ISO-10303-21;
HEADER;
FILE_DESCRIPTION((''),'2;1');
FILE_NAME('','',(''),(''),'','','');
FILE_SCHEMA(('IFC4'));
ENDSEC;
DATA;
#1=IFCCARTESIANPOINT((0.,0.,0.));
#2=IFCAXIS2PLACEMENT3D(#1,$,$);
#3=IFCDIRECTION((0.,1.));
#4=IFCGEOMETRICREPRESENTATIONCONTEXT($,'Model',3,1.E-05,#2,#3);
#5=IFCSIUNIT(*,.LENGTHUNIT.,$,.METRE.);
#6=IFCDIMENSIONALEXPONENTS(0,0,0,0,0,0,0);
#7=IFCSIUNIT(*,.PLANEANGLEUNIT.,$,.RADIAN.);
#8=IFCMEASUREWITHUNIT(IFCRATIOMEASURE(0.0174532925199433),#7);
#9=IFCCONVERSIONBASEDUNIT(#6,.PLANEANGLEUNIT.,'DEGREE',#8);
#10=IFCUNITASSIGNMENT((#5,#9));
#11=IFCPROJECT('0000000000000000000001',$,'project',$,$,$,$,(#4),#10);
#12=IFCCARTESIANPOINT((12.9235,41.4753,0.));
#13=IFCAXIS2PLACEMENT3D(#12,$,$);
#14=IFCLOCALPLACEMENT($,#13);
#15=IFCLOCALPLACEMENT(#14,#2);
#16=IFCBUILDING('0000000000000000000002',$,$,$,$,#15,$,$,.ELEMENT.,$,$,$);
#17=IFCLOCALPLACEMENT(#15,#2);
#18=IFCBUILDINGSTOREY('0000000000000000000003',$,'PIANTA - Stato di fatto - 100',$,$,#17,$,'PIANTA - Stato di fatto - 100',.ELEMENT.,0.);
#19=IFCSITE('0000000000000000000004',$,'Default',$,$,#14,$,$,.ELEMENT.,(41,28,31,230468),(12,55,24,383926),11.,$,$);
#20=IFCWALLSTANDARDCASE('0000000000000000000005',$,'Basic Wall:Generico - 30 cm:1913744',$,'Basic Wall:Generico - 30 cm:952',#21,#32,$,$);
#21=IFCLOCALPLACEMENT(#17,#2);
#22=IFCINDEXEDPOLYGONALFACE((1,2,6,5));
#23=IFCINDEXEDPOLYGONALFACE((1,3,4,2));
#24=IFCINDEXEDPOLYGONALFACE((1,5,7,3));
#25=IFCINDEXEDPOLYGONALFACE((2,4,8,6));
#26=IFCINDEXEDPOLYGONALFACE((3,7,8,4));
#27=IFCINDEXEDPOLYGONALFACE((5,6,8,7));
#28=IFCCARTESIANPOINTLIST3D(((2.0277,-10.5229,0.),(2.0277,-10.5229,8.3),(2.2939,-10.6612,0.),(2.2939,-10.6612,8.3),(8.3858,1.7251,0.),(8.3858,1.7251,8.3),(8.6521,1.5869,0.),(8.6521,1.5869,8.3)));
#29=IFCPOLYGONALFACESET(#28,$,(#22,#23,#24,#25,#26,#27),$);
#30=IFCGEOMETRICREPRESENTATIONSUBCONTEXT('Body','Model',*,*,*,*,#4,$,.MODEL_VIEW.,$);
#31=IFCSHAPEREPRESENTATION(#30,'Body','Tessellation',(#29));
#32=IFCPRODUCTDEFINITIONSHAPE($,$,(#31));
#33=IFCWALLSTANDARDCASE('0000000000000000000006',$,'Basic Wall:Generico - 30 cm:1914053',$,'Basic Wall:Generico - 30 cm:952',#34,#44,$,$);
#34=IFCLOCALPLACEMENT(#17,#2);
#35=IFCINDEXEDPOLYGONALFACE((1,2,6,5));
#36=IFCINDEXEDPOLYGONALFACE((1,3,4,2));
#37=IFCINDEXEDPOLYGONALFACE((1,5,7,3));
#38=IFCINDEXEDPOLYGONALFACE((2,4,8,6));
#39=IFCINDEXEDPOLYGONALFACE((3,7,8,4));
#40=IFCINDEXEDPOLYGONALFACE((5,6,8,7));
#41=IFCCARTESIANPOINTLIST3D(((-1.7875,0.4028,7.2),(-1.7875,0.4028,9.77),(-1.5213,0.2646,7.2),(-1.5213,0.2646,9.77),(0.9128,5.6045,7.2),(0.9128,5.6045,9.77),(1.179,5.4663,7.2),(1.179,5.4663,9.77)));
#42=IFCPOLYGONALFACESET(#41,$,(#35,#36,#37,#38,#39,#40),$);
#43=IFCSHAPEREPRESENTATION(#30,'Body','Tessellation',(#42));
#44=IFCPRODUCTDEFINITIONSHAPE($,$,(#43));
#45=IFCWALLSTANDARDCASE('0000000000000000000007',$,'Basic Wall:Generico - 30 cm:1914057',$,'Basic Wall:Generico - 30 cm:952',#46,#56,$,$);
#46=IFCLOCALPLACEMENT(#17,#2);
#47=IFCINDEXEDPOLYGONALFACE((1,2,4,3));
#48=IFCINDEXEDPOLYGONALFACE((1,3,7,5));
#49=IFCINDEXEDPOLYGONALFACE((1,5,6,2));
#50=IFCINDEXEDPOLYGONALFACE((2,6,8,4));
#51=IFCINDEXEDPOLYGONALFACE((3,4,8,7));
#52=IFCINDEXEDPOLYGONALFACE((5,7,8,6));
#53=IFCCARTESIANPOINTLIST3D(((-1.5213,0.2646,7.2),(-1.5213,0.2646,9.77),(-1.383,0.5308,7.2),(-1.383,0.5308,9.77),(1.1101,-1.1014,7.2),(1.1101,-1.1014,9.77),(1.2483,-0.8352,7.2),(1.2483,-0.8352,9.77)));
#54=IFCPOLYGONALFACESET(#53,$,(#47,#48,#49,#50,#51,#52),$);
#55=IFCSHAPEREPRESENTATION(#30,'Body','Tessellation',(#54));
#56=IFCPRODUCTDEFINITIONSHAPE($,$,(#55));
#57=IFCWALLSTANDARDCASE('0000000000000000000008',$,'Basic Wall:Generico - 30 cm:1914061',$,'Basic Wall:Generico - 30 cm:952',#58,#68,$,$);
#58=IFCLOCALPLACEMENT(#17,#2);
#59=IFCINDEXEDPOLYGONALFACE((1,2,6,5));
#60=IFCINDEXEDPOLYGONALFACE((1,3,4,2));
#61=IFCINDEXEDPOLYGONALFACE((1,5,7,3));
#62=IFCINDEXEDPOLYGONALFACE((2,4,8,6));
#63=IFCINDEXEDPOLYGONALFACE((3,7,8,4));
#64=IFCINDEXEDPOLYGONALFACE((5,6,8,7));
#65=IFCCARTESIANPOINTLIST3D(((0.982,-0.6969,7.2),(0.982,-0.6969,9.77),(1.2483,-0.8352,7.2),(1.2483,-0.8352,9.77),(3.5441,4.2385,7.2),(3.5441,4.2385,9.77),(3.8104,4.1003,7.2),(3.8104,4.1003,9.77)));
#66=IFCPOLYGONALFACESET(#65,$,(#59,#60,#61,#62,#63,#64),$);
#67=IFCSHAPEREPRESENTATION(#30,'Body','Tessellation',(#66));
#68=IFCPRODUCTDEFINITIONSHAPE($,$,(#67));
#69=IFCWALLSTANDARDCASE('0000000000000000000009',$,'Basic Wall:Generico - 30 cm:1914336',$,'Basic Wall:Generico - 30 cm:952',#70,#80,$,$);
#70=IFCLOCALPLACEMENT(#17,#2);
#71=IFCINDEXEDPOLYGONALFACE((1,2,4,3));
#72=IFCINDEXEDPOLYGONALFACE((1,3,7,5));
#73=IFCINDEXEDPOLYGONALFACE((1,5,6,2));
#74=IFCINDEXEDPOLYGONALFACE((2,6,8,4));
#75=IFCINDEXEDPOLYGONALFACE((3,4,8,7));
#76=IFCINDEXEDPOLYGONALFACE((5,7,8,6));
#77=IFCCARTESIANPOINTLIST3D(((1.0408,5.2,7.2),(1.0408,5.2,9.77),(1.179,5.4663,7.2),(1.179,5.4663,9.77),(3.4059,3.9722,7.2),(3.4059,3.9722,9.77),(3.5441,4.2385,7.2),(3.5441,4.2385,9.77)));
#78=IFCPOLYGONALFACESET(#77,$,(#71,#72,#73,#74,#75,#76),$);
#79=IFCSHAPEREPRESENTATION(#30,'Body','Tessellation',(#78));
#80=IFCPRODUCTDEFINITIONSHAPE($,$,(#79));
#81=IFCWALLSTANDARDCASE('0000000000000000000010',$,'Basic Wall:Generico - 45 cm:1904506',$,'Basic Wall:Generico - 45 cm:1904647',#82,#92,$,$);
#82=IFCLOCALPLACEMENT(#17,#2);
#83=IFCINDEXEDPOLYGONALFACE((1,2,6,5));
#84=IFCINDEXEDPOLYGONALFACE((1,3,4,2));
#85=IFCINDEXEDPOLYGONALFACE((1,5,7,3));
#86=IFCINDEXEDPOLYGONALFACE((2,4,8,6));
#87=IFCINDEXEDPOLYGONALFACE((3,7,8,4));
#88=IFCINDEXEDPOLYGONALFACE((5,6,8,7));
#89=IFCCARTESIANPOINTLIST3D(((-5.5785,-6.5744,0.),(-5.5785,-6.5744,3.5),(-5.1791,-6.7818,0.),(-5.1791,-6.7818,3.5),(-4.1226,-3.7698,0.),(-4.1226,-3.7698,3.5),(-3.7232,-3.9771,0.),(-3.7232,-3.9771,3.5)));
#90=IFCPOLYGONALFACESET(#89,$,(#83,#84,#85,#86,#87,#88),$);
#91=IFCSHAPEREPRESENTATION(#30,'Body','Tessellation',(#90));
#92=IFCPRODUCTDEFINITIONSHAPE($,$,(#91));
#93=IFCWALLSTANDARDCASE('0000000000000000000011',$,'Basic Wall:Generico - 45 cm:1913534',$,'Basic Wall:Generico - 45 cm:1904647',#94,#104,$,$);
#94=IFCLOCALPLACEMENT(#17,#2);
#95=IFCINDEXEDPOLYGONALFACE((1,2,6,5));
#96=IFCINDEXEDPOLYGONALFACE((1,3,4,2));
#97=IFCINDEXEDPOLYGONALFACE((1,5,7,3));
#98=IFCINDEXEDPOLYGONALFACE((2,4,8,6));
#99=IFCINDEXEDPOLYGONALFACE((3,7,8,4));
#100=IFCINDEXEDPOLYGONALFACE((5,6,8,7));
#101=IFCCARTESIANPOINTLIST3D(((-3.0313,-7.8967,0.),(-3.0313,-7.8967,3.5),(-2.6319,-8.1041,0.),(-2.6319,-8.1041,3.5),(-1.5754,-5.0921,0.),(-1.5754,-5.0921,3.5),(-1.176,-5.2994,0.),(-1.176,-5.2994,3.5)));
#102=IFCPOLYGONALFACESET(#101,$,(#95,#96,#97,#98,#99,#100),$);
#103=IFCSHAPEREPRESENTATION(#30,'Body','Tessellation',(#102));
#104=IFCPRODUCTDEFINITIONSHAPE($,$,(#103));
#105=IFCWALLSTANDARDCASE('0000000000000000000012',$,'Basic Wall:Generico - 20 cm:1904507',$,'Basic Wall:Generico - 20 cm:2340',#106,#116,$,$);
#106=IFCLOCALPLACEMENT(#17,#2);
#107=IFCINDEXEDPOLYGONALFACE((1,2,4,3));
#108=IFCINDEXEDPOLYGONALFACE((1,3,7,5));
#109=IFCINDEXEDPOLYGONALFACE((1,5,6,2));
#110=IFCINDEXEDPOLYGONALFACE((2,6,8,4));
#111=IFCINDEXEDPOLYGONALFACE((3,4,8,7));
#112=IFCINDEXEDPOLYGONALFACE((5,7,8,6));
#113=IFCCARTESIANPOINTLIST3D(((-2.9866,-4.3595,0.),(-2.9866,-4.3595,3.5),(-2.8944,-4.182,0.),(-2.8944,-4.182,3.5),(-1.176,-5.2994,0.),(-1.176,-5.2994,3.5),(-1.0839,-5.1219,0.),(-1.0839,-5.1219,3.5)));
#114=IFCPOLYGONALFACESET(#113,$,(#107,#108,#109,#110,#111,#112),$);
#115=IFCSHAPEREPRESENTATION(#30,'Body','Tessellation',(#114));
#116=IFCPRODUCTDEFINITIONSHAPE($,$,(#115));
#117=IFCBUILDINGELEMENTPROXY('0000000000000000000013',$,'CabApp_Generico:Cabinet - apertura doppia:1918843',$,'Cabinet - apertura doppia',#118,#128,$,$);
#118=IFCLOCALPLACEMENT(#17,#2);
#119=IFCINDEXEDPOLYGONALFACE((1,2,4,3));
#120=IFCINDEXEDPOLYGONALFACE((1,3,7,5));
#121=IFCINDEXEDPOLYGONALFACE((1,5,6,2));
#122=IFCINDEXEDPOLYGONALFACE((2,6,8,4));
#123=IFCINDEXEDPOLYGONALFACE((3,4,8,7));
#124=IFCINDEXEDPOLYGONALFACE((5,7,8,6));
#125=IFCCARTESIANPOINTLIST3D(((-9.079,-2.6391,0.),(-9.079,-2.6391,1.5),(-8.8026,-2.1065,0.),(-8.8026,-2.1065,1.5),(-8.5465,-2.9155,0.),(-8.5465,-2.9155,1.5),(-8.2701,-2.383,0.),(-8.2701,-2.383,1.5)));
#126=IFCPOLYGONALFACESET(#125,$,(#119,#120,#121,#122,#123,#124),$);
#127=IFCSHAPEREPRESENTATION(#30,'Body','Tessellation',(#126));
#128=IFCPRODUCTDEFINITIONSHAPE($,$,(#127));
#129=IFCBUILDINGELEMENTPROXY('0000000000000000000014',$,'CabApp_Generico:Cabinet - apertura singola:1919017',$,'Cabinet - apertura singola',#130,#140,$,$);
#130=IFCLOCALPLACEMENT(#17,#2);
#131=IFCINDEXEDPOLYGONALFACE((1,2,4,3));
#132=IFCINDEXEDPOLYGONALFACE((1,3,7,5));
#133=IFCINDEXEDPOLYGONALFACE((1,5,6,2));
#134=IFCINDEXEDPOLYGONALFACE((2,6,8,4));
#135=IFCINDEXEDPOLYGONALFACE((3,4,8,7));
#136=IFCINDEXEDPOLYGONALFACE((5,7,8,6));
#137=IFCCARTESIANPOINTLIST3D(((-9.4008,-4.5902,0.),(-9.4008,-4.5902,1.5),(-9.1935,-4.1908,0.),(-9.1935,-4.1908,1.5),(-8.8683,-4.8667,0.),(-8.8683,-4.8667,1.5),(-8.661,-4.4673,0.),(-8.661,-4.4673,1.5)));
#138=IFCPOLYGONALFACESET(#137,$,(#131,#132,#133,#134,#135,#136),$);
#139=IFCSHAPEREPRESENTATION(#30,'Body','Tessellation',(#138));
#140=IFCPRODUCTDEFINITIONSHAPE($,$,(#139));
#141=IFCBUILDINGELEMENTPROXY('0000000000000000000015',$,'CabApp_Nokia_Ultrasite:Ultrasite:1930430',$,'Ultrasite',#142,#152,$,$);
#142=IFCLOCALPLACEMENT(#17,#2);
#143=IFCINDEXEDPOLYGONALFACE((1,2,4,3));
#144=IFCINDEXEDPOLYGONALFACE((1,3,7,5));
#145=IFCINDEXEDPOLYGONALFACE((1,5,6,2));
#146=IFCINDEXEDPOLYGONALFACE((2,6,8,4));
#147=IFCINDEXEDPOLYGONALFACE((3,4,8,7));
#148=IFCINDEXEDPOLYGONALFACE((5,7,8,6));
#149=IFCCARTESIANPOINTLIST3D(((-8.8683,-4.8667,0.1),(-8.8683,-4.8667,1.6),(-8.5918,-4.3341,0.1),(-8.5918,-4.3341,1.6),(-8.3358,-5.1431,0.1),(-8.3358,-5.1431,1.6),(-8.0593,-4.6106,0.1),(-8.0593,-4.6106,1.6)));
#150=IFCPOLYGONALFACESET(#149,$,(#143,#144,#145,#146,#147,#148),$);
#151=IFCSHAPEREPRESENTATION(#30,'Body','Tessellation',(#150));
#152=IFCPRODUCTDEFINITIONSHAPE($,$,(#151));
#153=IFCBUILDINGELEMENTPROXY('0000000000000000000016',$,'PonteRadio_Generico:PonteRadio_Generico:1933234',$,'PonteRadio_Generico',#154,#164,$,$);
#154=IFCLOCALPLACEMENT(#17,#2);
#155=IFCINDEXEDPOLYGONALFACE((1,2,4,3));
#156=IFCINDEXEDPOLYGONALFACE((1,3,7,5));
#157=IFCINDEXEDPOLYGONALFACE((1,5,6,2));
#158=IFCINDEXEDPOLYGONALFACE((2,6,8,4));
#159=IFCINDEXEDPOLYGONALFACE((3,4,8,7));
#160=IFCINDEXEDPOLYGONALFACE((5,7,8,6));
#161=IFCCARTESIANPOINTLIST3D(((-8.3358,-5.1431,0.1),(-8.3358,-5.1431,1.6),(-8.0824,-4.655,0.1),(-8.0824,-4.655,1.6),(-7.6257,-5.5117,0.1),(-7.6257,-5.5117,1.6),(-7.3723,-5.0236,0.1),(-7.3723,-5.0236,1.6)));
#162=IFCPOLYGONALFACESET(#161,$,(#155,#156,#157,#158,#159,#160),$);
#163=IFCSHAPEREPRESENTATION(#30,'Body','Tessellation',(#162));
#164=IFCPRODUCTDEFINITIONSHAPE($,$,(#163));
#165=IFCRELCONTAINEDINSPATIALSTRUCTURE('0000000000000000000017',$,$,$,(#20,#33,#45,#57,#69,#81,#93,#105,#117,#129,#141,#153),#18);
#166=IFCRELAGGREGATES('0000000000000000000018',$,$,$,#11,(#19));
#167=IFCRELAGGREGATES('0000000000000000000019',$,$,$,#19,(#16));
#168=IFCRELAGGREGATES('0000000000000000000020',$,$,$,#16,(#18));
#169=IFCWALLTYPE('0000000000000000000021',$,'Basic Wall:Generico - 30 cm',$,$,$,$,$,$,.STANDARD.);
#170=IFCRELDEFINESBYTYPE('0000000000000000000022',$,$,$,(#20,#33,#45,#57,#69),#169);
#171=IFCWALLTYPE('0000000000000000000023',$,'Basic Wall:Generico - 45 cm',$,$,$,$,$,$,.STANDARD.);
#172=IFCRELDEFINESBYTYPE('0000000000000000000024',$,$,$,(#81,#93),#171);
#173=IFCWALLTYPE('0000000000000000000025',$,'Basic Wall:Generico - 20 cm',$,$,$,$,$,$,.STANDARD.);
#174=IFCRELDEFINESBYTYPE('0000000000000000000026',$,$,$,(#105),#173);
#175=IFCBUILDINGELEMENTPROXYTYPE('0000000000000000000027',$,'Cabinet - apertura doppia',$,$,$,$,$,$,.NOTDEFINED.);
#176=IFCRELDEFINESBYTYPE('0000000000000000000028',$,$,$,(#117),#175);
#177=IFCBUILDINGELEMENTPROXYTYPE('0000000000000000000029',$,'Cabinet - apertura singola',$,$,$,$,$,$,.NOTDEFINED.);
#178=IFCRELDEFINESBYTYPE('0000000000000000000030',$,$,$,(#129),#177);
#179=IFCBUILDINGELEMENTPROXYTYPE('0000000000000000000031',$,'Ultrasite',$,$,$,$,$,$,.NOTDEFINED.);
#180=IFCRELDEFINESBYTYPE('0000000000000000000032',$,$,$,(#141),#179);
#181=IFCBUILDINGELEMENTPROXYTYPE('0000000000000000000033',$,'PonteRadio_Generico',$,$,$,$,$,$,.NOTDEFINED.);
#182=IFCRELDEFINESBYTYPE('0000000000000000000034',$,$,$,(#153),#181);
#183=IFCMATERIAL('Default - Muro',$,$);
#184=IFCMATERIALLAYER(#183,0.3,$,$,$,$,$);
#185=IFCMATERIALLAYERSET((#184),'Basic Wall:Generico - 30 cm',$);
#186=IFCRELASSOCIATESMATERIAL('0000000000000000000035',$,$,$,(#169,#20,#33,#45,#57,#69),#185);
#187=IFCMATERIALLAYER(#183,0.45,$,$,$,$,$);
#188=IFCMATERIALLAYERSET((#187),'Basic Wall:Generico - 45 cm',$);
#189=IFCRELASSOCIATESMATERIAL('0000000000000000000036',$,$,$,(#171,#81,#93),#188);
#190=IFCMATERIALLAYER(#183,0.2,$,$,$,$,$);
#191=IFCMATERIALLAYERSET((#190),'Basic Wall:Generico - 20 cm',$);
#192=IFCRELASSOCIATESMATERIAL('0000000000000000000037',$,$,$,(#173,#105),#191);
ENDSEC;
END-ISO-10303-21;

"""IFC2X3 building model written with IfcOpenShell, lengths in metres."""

from ifc_helpers import new_model, entity, si_unit, converted_unit, direction, frame, frame_2d, origin, origin_2d_with_axis, place, context, subcontext, project, spatial, polyline, rectangle, extrude, clip, bounded_halfspace, source, transform, mapped, material, layer, layer_set, layer_usage, type_object, type_shapes, element, save


model = new_model("IFC2X3")

# Units and contexts
model_context = context("Model", 3, precision=1e-05, world=origin(), true_north=direction((0.0, 1.0)))
body_context = subcontext(model_context, "Body", "Model", "MODEL_VIEW")
ifc_project = project(units=[si_unit("LENGTHUNIT", "METRE"), converted_unit("PLANEANGLEUNIT", "DEGREE", entity("IfcRatioMeasure", 0.0174532925199433), si_unit("PLANEANGLEUNIT", "RADIAN"), dimensions=[0, 0, 0, 0, 0, 0, 0])], contexts=[model_context])

# Site, building, storey
site_placement = place(None, frame((12.9235, 41.4753, 0.0)))
site = spatial("IfcSite", under=ifc_project, at=site_placement, Name="Default", CompositionType="ELEMENT", RefLatitude=(41, 28, 31, 230468), RefLongitude=(12, 55, 24, 383926), RefElevation=11.0)
building_placement = place(site_placement, origin())
building = spatial("IfcBuilding", under=site, at=building_placement, CompositionType="ELEMENT")
storey_placement = place(building_placement, origin())
storey = spatial("IfcBuildingStorey", under=building, at=storey_placement, Name="PIANTA - Stato di fatto - 100", LongName="PIANTA - Stato di fatto - 100", CompositionType="ELEMENT", Elevation=0.0)

# Walls
ifc_material_1 = material(Name="Default - Muro")
ifc_layer_1 = layer(ifc_material_1, 0.3)
ifc_layer_set_1 = layer_set([ifc_layer_1], Name="Basic Wall:Generico - 30 cm")
wall_type_1 = type_object("IfcWallType", Name="Basic Wall:Generico - 30 cm", PredefinedType="STANDARD", material=ifc_layer_set_1)
ifc_layer_usage_1 = layer_usage(ifc_layer_set_1, "AXIS2", "NEGATIVE", 0.15)
wall_1_placement = place(storey_placement, frame((8.519, 1.656, 0.0), z_axis=(0.0, 0.0, 1.0), x_axis=(-0.460735, -0.887538, 0.0)))
element("IfcWallStandardCase", 1, at=wall_1_placement, inside=storey, type_object=wall_type_1, material=ifc_layer_usage_1, Name="Basic Wall:Generico - 30 cm:1913744", ObjectType="Basic Wall:Generico - 30 cm:952", context=body_context, shape_type="SweptSolid", body=[
    extrude(rectangle(XDim=13.8, YDim=0.3, at=frame_2d((6.9, 0.0), x_axis=(-1.0, 0.0))), origin(), (0.0, 0.0, 1.0), 8.3),
])
ifc_layer_usage_2 = layer_usage(ifc_layer_set_1, "AXIS2", "POSITIVE", -0.15)
wall_2_placement = place(storey_placement, frame((1.0459, 5.5354, 7.2), z_axis=(0.0, 0.0, 1.0), x_axis=(-0.460735, -0.887538, 0.0)))
element("IfcWallStandardCase", 2, at=wall_2_placement, inside=storey, type_object=wall_type_1, material=ifc_layer_usage_2, Name="Basic Wall:Generico - 30 cm:1914053", ObjectType="Basic Wall:Generico - 30 cm:952", context=body_context, shape_type="SweptSolid", body=[
    extrude(rectangle(XDim=5.8608, YDim=0.3, at=frame_2d((2.9304, 0.0), x_axis=(-1.0, 0.0))), origin(), (0.0, 0.0, 1.0), 2.57),
])
ifc_layer_usage_3 = layer_usage(ifc_layer_set_1, "AXIS2", "POSITIVE", -0.15)
wall_3_placement = place(storey_placement, frame((-1.4522, 0.3977, 7.2), z_axis=(0.0, 0.0, 1.0), x_axis=(0.887538, -0.460735, 0.0)))
element("IfcWallStandardCase", 3, at=wall_3_placement, inside=storey, type_object=wall_type_1, material=ifc_layer_usage_3, Name="Basic Wall:Generico - 30 cm:1914057", ObjectType="Basic Wall:Generico - 30 cm:952", context=body_context, shape_type="SweptSolid", body=[
    extrude(rectangle(XDim=2.9648, YDim=0.3, at=frame_2d((1.4824, 0.0), x_axis=(-1.0, 0.0))), origin(), (0.0, 0.0, 1.0), 2.57),
])
ifc_layer_usage_4 = layer_usage(ifc_layer_set_1, "AXIS2", "POSITIVE", -0.15)
wall_4_placement = place(storey_placement, frame((1.1152, -0.766, 7.2), z_axis=(0.0, 0.0, 1.0), x_axis=(0.460735, 0.887538, 0.0)))
element("IfcWallStandardCase", 4, at=wall_4_placement, inside=storey, type_object=wall_type_1, material=ifc_layer_usage_4, Name="Basic Wall:Generico - 30 cm:1914061", ObjectType="Basic Wall:Generico - 30 cm:952", context=body_context, shape_type="SweptSolid", body=[
    extrude(rectangle(XDim=5.5608, YDim=0.3, at=frame_2d((2.7804, 0.0), x_axis=(-1.0, 0.0))), origin(), (0.0, 0.0, 1.0), 2.57),
])
ifc_layer_usage_5 = layer_usage(ifc_layer_set_1, "AXIS2", "POSITIVE", -0.15)
wall_5_placement = place(storey_placement, frame((1.1099, 5.3331, 7.2), z_axis=(0.0, 0.0, 1.0), x_axis=(0.887538, -0.460735, 0.0)))
element("IfcWallStandardCase", 5, at=wall_5_placement, inside=storey, type_object=wall_type_1, material=ifc_layer_usage_5, Name="Basic Wall:Generico - 30 cm:1914336", ObjectType="Basic Wall:Generico - 30 cm:952", context=body_context, shape_type="Clipping", body=[
    clip(extrude(rectangle(XDim=2.6648, YDim=0.3, at=frame_2d((1.3324, 0.0), x_axis=(-1.0, 0.0))), origin(), (0.0, 0.0, 1.0), 2.57), bounded_halfspace(frame((0.0102, -0.15, 2.57), z_axis=(0.0, 0.0, -1.0), x_axis=(-1.0, 0.0, 0.0)), True, frame((0.0102, -0.15, 2.57)), polyline([(0.0, 0.0), (2.6546, 0.0), (2.6546, 0.3), (0.0, 0.3), (0.0, 0.0)]))),
])
ifc_layer_2 = layer(ifc_material_1, 0.45)
ifc_layer_set_2 = layer_set([ifc_layer_2], Name="Basic Wall:Generico - 45 cm")
ifc_layer_usage_6 = layer_usage(ifc_layer_set_2, "AXIS2", "POSITIVE", -0.225)
wall_type_2 = type_object("IfcWallType", Name="Basic Wall:Generico - 45 cm", PredefinedType="STANDARD", material=ifc_layer_set_2)
wall_6_placement = place(storey_placement, frame((-5.3788, -6.6781, 0.0), z_axis=(0.0, 0.0, 1.0), x_axis=(0.460735, 0.887538, 0.0)))
element("IfcWallStandardCase", 6, at=wall_6_placement, inside=storey, type_object=wall_type_2, material=ifc_layer_usage_6, Name="Basic Wall:Generico - 45 cm:1904506", ObjectType="Basic Wall:Generico - 45 cm:1904647", context=body_context, shape_type="SweptSolid", body=[
    extrude(rectangle(XDim=3.16, YDim=0.45, at=frame_2d((1.58, 0.0), x_axis=(-1.0, 0.0))), origin(), (0.0, 0.0, 1.0), 3.5),
])
ifc_layer_usage_7 = layer_usage(ifc_layer_set_2, "AXIS2", "POSITIVE", -0.225)
wall_7_placement = place(storey_placement, frame((-2.8316, -8.0004, 0.0), z_axis=(0.0, 0.0, 1.0), x_axis=(0.460735, 0.887538, 0.0)))
element("IfcWallStandardCase", 7, at=wall_7_placement, inside=storey, type_object=wall_type_2, material=ifc_layer_usage_7, Name="Basic Wall:Generico - 45 cm:1913534", ObjectType="Basic Wall:Generico - 45 cm:1904647", context=body_context, shape_type="SweptSolid", body=[
    extrude(rectangle(XDim=3.16, YDim=0.45, at=frame_2d((1.58, 0.0), x_axis=(-1.0, 0.0))), origin(), (0.0, 0.0, 1.0), 3.5),
])
ifc_layer_3 = layer(ifc_material_1, 0.2)
ifc_layer_set_3 = layer_set([ifc_layer_3], Name="Basic Wall:Generico - 20 cm")
ifc_layer_usage_8 = layer_usage(ifc_layer_set_3, "AXIS2", "POSITIVE", -0.1)
wall_type_3 = type_object("IfcWallType", Name="Basic Wall:Generico - 20 cm", PredefinedType="STANDARD", material=ifc_layer_set_3)
wall_8_placement = place(storey_placement, frame((-1.1299, -5.2107, 0.0), z_axis=(0.0, 0.0, 1.0), x_axis=(-0.887538, 0.460735, 0.0)))
element("IfcWallStandardCase", 8, at=wall_8_placement, inside=storey, type_object=wall_type_3, material=ifc_layer_usage_8, Name="Basic Wall:Generico - 20 cm:1904507", ObjectType="Basic Wall:Generico - 20 cm:2340", context=body_context, shape_type="SweptSolid", body=[
    extrude(rectangle(XDim=2.04, YDim=0.2, at=frame_2d((1.02, 0.0), x_axis=(-1.0, 0.0))), origin(), (0.0, 0.0, 1.0), 3.5),
])

# Building element proxies
building_element_proxy_type_1 = type_object("IfcBuildingElementProxyType", Name="Cabinet - apertura doppia", PredefinedType="NOTDEFINED")
shared_shape_1 = source(origin(), body_context, "Body", "SweptSolid", [
    extrude(rectangle(XDim=0.6, YDim=0.6, at=origin_2d_with_axis()), frame((0.0, 0.0, 0.0), z_axis=(0.0, 0.0, 1.0), x_axis=(0.0, 1.0, 0.0)), (0.0, 0.0, 1.0), 1.5),
])
type_shapes(building_element_proxy_type_1, [shared_shape_1])
proxy_1_placement = place(storey_placement, frame((-8.6745, -2.511, 0.0), z_axis=(0.0, 0.0, 1.0), x_axis=(0.460735, 0.887538, 0.0)))
element("IfcBuildingElementProxy", 9, at=proxy_1_placement, inside=storey, type_object=building_element_proxy_type_1, Name="CabApp_Generico:Cabinet - apertura doppia:1918843", ObjectType="Cabinet - apertura doppia", context=body_context, shape_type="MappedRepresentation", body=[
    mapped(shared_shape_1, transform((0.0, 0.0, 0.0), scale=1.0)),
])
building_element_proxy_type_2 = type_object("IfcBuildingElementProxyType", Name="Cabinet - apertura singola", PredefinedType="NOTDEFINED")
shared_shape_2 = source(origin(), body_context, "Body", "SweptSolid", [
    extrude(rectangle(XDim=0.6, YDim=0.45, at=frame_2d((0.0, 0.0), x_axis=(1.0, 0.0))), frame((0.0, 0.0, 0.0), z_axis=(0.0, 0.0, 1.0), x_axis=(-1.0, 0.0, 0.0)), (0.0, 0.0, 1.0), 1.5),
])
type_shapes(building_element_proxy_type_2, [shared_shape_2])
proxy_2_placement = place(storey_placement, frame((-9.0309, -4.5288, 0.0), z_axis=(0.0, 0.0, 1.0), x_axis=(-0.887538, 0.460735, 0.0)))
element("IfcBuildingElementProxy", 10, at=proxy_2_placement, inside=storey, type_object=building_element_proxy_type_2, Name="CabApp_Generico:Cabinet - apertura singola:1919017", ObjectType="Cabinet - apertura singola", context=body_context, shape_type="MappedRepresentation", body=[
    mapped(shared_shape_2, transform((0.0, 0.0, 0.0), scale=1.0)),
])
building_element_proxy_type_3 = type_object("IfcBuildingElementProxyType", Name="Ultrasite", PredefinedType="NOTDEFINED")
shared_shape_3 = source(origin(), body_context, "Body", "SweptSolid", [
    extrude(rectangle(XDim=0.6, YDim=0.6, at=origin_2d_with_axis()), frame((0.3, 0.3, 0.0), z_axis=(0.0, 0.0, 1.0), x_axis=(0.0, 1.0, 0.0)), (0.0, 0.0, 1.0), 1.5),
])
type_shapes(building_element_proxy_type_3, [shared_shape_3])
proxy_3_placement = place(storey_placement, frame((-8.8683, -4.8667, 0.1), z_axis=(0.0, 0.0, 1.0), x_axis=(0.887538, -0.460735, 0.0)))
element("IfcBuildingElementProxy", 11, at=proxy_3_placement, inside=storey, type_object=building_element_proxy_type_3, Name="CabApp_Nokia_Ultrasite:Ultrasite:1930430", ObjectType="Ultrasite", context=body_context, shape_type="MappedRepresentation", body=[
    mapped(shared_shape_3, transform((0.0, 0.0, 0.0), scale=1.0)),
])
building_element_proxy_type_4 = type_object("IfcBuildingElementProxyType", Name="PonteRadio_Generico", PredefinedType="NOTDEFINED")
shared_shape_4 = source(origin(), body_context, "Body", "SweptSolid", [
    extrude(rectangle(XDim=0.55, YDim=0.8, at=origin_2d_with_axis()), frame((0.4, 0.275, 0.0), z_axis=(0.0, 0.0, 1.0), x_axis=(0.0, 1.0, 0.0)), (0.0, 0.0, 1.0), 1.5),
])
type_shapes(building_element_proxy_type_4, [shared_shape_4])
proxy_4_placement = place(storey_placement, frame((-8.3358, -5.1431, 0.1), z_axis=(0.0, 0.0, 1.0), x_axis=(0.887538, -0.460735, 0.0)))
element("IfcBuildingElementProxy", 12, at=proxy_4_placement, inside=storey, type_object=building_element_proxy_type_4, Name="PonteRadio_Generico:PonteRadio_Generico:1933234", ObjectType="PonteRadio_Generico", context=body_context, shape_type="MappedRepresentation", body=[
    mapped(shared_shape_4, transform((0.0, 0.0, 0.0), scale=1.0)),
])

save(model, "model.ifc")
